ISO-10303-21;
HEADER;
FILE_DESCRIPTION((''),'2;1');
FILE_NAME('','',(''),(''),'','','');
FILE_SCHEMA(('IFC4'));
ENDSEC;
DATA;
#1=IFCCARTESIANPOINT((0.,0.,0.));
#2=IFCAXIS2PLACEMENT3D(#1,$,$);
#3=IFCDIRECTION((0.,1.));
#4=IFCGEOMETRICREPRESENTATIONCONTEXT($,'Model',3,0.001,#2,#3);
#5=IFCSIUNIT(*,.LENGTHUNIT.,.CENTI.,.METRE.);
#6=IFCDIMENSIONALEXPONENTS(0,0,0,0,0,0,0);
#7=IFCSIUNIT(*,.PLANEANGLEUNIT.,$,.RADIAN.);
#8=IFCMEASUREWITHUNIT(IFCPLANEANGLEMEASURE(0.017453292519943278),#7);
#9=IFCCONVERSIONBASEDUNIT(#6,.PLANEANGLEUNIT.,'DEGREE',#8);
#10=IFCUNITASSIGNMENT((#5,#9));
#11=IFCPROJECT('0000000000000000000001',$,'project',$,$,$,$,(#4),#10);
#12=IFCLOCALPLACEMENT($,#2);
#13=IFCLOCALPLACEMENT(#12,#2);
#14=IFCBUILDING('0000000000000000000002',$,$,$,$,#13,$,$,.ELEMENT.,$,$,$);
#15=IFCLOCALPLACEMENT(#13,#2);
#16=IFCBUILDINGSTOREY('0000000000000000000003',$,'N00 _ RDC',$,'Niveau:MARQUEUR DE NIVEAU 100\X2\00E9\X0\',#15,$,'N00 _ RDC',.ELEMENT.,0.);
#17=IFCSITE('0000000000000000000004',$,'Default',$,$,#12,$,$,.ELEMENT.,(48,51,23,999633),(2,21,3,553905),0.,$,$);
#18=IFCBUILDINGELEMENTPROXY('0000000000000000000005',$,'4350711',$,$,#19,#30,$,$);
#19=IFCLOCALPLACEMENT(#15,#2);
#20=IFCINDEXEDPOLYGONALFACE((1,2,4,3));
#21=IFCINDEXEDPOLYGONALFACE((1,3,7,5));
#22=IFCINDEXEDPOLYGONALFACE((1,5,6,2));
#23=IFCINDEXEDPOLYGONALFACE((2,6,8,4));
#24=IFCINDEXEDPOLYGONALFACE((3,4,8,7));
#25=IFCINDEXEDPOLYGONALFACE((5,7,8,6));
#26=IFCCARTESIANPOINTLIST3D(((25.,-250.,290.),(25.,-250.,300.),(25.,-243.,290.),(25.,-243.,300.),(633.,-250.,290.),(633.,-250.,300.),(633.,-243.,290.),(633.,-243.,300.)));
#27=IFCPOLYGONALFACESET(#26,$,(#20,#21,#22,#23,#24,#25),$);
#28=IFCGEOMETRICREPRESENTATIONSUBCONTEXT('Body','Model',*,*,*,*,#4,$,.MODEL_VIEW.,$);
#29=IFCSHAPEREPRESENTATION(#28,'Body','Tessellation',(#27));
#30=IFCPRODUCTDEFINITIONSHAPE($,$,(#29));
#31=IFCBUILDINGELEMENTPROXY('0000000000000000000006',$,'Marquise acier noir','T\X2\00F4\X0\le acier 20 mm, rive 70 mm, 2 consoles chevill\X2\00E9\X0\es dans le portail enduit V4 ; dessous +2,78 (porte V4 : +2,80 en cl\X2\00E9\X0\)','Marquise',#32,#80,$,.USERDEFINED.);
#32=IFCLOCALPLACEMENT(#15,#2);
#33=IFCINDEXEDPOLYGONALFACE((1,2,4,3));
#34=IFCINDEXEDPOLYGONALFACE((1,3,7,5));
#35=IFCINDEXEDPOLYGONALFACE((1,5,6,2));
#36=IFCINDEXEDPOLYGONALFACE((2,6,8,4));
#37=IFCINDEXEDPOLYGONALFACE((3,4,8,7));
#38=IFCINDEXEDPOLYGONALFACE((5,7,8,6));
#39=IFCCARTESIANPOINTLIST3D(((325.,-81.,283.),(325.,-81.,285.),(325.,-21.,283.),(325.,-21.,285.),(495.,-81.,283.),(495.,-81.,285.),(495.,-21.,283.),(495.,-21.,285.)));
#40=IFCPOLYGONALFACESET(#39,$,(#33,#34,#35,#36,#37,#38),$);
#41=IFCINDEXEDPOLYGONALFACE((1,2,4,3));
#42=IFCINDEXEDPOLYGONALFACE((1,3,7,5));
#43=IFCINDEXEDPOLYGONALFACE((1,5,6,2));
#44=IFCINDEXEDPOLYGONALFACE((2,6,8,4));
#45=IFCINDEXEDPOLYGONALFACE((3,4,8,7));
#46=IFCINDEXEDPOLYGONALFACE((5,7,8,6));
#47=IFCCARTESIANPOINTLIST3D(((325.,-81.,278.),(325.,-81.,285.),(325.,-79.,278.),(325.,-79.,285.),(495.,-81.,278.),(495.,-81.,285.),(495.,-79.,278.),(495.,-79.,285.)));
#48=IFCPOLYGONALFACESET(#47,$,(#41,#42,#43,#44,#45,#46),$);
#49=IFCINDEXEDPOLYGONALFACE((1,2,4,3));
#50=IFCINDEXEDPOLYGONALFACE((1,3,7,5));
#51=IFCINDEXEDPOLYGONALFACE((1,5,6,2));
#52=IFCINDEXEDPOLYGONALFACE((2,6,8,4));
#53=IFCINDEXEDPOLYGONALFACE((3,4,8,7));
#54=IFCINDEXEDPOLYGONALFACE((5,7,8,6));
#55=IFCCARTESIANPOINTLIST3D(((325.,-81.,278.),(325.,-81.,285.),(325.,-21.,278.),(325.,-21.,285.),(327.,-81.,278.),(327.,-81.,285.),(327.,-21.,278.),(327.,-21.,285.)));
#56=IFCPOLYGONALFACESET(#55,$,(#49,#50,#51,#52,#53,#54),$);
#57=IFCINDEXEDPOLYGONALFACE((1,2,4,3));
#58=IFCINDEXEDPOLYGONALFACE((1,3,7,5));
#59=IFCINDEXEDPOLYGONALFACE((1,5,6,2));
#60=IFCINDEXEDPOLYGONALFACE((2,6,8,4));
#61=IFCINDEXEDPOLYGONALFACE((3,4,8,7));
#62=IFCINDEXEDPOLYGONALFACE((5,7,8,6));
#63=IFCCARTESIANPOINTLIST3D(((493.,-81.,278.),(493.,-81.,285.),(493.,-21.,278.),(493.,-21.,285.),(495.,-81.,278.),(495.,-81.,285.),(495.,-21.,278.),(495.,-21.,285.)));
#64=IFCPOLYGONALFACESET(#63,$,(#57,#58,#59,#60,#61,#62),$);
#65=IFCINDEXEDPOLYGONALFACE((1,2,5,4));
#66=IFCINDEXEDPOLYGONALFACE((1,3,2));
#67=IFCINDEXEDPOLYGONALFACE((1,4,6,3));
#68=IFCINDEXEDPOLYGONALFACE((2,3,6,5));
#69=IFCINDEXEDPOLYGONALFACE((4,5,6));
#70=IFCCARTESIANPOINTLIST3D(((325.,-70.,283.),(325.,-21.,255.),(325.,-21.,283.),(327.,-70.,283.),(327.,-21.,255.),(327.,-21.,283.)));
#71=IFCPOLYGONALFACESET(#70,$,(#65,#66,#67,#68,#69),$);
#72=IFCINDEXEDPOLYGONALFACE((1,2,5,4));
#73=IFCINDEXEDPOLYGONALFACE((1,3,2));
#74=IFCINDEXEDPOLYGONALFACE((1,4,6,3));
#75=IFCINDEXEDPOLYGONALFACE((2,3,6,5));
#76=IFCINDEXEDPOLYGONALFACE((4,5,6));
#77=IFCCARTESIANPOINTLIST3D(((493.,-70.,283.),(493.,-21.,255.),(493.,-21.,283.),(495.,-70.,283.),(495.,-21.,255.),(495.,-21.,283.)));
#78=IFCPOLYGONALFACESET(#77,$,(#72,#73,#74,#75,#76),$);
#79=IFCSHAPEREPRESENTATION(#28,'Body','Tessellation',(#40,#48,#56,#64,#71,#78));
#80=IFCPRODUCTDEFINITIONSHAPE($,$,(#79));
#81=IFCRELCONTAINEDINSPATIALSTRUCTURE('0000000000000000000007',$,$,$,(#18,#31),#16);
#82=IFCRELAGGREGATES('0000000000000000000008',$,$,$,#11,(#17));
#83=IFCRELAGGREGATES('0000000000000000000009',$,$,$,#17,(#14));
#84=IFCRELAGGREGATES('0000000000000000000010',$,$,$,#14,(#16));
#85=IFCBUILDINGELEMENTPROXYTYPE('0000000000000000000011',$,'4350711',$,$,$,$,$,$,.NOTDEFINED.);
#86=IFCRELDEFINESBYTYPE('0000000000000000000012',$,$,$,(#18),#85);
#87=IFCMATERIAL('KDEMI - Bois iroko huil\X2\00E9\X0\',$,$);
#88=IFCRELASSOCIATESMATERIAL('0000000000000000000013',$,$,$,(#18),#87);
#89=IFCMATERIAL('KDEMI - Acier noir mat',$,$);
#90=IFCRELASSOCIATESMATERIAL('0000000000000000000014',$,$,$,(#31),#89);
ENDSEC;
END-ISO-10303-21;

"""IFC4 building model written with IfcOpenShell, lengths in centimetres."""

from ifc_helpers import new_model, entity, si_unit, converted_unit, direction, frame, frame_2d, origin, origin_with_axes, place, context, subcontext, project, spatial, polyline, rectangle, outline, extrude, material, type_object, element, save


model = new_model("IFC4")

# Units and contexts
model_context = context("Model", 3, precision=0.001, world=origin(), true_north=direction((0.0, 1.0)))
body_context = subcontext(model_context, "Body", "Model", "MODEL_VIEW")
ifc_project = project(units=[si_unit("LENGTHUNIT", "METRE", prefix="CENTI"), converted_unit("PLANEANGLEUNIT", "DEGREE", entity("IfcPlaneAngleMeasure", 0.017453292519943278), si_unit("PLANEANGLEUNIT", "RADIAN"), dimensions=[0, 0, 0, 0, 0, 0, 0])], contexts=[model_context])

# Site, building, storey
site_placement = place(None, origin())
site = spatial("IfcSite", under=ifc_project, at=site_placement, Name="Default", CompositionType="ELEMENT", RefLatitude=(48, 51, 23, 999633), RefLongitude=(2, 21, 3, 553905), RefElevation=0.0)
building_placement = place(site_placement, origin())
building = spatial("IfcBuilding", under=site, at=building_placement, CompositionType="ELEMENT")
storey_placement = place(building_placement, origin())
storey = spatial("IfcBuildingStorey", under=building, at=storey_placement, Name="N00 _ RDC", ObjectType="Niveau:MARQUEUR DE NIVEAU 100é", LongName="N00 _ RDC", CompositionType="ELEMENT", Elevation=0.0)

# Shared definitions
ifc_material_1 = material(Name="KDEMI - Bois iroko huilé")

# Building element proxies
building_element_proxy_type_1 = type_object("IfcBuildingElementProxyType", Name="4350711", PredefinedType="NOTDEFINED")
proxy_1_placement = place(storey_placement, frame((0.0, 0.0, 25.0), z_axis=(0.0, 0.0, 1.0), x_axis=(1.0, 0.0, 0.0)))
element("IfcBuildingElementProxy", 1, at=proxy_1_placement, inside=storey, type_object=building_element_proxy_type_1, material=ifc_material_1, Name="4350711", context=body_context, shape_type="SweptSolid", body=[
    extrude(rectangle(XDim=608.0, YDim=7.0, at=frame_2d((0.0, 0.0), x_axis=(1.0, 0.0))), frame((329.0, -246.5, 265.0)), (0.0, 0.0, 1.0), 10.0),
])
ifc_material_2 = material(Name="KDEMI - Acier noir mat")
proxy_2_placement = place(storey_placement, origin_with_axes())
element("IfcBuildingElementProxy", 2, at=proxy_2_placement, inside=storey, material=ifc_material_2, Name="Marquise acier noir", Description="Tôle acier 20 mm, rive 70 mm, 2 consoles chevillées dans le portail enduit V4 ; dessous +2,78 (porte V4 : +2,80 en clé)", ObjectType="Marquise", PredefinedType="USERDEFINED", context=body_context, shape_type="SweptSolid", body=[
    extrude(rectangle(XDim=170.0, YDim=60.0, at=frame_2d((410.0, -51.0))), frame((0.0, 0.0, 283.0)), (0.0, 0.0, 1.0), 2.0),
    extrude(rectangle(XDim=170.0, YDim=2.0, at=frame_2d((410.0, -80.0))), frame((0.0, 0.0, 278.0)), (0.0, 0.0, 1.0), 7.0),
    extrude(rectangle(XDim=2.0, YDim=60.0, at=frame_2d((326.0, -51.0))), frame((0.0, 0.0, 278.0)), (0.0, 0.0, 1.0), 7.0),
    extrude(rectangle(XDim=2.0, YDim=60.0, at=frame_2d((494.0, -51.0))), frame((0.0, 0.0, 278.0)), (0.0, 0.0, 1.0), 7.0),
    extrude(outline(polyline([(-21.0, 255.0), (-70.0, 283.0), (-21.0, 283.0), (-21.0, 255.0)])), frame((325.0, 0.0, 0.0), z_axis=(1.0, 0.0, 0.0), x_axis=(0.0, 1.0, 0.0)), (0.0, 0.0, 1.0), 2.0),
    extrude(outline(polyline([(-21.0, 255.0), (-70.0, 283.0), (-21.0, 283.0), (-21.0, 255.0)])), frame((493.0, 0.0, 0.0), z_axis=(1.0, 0.0, 0.0), x_axis=(0.0, 1.0, 0.0)), (0.0, 0.0, 1.0), 2.0),
])

save(model, "model.ifc")
